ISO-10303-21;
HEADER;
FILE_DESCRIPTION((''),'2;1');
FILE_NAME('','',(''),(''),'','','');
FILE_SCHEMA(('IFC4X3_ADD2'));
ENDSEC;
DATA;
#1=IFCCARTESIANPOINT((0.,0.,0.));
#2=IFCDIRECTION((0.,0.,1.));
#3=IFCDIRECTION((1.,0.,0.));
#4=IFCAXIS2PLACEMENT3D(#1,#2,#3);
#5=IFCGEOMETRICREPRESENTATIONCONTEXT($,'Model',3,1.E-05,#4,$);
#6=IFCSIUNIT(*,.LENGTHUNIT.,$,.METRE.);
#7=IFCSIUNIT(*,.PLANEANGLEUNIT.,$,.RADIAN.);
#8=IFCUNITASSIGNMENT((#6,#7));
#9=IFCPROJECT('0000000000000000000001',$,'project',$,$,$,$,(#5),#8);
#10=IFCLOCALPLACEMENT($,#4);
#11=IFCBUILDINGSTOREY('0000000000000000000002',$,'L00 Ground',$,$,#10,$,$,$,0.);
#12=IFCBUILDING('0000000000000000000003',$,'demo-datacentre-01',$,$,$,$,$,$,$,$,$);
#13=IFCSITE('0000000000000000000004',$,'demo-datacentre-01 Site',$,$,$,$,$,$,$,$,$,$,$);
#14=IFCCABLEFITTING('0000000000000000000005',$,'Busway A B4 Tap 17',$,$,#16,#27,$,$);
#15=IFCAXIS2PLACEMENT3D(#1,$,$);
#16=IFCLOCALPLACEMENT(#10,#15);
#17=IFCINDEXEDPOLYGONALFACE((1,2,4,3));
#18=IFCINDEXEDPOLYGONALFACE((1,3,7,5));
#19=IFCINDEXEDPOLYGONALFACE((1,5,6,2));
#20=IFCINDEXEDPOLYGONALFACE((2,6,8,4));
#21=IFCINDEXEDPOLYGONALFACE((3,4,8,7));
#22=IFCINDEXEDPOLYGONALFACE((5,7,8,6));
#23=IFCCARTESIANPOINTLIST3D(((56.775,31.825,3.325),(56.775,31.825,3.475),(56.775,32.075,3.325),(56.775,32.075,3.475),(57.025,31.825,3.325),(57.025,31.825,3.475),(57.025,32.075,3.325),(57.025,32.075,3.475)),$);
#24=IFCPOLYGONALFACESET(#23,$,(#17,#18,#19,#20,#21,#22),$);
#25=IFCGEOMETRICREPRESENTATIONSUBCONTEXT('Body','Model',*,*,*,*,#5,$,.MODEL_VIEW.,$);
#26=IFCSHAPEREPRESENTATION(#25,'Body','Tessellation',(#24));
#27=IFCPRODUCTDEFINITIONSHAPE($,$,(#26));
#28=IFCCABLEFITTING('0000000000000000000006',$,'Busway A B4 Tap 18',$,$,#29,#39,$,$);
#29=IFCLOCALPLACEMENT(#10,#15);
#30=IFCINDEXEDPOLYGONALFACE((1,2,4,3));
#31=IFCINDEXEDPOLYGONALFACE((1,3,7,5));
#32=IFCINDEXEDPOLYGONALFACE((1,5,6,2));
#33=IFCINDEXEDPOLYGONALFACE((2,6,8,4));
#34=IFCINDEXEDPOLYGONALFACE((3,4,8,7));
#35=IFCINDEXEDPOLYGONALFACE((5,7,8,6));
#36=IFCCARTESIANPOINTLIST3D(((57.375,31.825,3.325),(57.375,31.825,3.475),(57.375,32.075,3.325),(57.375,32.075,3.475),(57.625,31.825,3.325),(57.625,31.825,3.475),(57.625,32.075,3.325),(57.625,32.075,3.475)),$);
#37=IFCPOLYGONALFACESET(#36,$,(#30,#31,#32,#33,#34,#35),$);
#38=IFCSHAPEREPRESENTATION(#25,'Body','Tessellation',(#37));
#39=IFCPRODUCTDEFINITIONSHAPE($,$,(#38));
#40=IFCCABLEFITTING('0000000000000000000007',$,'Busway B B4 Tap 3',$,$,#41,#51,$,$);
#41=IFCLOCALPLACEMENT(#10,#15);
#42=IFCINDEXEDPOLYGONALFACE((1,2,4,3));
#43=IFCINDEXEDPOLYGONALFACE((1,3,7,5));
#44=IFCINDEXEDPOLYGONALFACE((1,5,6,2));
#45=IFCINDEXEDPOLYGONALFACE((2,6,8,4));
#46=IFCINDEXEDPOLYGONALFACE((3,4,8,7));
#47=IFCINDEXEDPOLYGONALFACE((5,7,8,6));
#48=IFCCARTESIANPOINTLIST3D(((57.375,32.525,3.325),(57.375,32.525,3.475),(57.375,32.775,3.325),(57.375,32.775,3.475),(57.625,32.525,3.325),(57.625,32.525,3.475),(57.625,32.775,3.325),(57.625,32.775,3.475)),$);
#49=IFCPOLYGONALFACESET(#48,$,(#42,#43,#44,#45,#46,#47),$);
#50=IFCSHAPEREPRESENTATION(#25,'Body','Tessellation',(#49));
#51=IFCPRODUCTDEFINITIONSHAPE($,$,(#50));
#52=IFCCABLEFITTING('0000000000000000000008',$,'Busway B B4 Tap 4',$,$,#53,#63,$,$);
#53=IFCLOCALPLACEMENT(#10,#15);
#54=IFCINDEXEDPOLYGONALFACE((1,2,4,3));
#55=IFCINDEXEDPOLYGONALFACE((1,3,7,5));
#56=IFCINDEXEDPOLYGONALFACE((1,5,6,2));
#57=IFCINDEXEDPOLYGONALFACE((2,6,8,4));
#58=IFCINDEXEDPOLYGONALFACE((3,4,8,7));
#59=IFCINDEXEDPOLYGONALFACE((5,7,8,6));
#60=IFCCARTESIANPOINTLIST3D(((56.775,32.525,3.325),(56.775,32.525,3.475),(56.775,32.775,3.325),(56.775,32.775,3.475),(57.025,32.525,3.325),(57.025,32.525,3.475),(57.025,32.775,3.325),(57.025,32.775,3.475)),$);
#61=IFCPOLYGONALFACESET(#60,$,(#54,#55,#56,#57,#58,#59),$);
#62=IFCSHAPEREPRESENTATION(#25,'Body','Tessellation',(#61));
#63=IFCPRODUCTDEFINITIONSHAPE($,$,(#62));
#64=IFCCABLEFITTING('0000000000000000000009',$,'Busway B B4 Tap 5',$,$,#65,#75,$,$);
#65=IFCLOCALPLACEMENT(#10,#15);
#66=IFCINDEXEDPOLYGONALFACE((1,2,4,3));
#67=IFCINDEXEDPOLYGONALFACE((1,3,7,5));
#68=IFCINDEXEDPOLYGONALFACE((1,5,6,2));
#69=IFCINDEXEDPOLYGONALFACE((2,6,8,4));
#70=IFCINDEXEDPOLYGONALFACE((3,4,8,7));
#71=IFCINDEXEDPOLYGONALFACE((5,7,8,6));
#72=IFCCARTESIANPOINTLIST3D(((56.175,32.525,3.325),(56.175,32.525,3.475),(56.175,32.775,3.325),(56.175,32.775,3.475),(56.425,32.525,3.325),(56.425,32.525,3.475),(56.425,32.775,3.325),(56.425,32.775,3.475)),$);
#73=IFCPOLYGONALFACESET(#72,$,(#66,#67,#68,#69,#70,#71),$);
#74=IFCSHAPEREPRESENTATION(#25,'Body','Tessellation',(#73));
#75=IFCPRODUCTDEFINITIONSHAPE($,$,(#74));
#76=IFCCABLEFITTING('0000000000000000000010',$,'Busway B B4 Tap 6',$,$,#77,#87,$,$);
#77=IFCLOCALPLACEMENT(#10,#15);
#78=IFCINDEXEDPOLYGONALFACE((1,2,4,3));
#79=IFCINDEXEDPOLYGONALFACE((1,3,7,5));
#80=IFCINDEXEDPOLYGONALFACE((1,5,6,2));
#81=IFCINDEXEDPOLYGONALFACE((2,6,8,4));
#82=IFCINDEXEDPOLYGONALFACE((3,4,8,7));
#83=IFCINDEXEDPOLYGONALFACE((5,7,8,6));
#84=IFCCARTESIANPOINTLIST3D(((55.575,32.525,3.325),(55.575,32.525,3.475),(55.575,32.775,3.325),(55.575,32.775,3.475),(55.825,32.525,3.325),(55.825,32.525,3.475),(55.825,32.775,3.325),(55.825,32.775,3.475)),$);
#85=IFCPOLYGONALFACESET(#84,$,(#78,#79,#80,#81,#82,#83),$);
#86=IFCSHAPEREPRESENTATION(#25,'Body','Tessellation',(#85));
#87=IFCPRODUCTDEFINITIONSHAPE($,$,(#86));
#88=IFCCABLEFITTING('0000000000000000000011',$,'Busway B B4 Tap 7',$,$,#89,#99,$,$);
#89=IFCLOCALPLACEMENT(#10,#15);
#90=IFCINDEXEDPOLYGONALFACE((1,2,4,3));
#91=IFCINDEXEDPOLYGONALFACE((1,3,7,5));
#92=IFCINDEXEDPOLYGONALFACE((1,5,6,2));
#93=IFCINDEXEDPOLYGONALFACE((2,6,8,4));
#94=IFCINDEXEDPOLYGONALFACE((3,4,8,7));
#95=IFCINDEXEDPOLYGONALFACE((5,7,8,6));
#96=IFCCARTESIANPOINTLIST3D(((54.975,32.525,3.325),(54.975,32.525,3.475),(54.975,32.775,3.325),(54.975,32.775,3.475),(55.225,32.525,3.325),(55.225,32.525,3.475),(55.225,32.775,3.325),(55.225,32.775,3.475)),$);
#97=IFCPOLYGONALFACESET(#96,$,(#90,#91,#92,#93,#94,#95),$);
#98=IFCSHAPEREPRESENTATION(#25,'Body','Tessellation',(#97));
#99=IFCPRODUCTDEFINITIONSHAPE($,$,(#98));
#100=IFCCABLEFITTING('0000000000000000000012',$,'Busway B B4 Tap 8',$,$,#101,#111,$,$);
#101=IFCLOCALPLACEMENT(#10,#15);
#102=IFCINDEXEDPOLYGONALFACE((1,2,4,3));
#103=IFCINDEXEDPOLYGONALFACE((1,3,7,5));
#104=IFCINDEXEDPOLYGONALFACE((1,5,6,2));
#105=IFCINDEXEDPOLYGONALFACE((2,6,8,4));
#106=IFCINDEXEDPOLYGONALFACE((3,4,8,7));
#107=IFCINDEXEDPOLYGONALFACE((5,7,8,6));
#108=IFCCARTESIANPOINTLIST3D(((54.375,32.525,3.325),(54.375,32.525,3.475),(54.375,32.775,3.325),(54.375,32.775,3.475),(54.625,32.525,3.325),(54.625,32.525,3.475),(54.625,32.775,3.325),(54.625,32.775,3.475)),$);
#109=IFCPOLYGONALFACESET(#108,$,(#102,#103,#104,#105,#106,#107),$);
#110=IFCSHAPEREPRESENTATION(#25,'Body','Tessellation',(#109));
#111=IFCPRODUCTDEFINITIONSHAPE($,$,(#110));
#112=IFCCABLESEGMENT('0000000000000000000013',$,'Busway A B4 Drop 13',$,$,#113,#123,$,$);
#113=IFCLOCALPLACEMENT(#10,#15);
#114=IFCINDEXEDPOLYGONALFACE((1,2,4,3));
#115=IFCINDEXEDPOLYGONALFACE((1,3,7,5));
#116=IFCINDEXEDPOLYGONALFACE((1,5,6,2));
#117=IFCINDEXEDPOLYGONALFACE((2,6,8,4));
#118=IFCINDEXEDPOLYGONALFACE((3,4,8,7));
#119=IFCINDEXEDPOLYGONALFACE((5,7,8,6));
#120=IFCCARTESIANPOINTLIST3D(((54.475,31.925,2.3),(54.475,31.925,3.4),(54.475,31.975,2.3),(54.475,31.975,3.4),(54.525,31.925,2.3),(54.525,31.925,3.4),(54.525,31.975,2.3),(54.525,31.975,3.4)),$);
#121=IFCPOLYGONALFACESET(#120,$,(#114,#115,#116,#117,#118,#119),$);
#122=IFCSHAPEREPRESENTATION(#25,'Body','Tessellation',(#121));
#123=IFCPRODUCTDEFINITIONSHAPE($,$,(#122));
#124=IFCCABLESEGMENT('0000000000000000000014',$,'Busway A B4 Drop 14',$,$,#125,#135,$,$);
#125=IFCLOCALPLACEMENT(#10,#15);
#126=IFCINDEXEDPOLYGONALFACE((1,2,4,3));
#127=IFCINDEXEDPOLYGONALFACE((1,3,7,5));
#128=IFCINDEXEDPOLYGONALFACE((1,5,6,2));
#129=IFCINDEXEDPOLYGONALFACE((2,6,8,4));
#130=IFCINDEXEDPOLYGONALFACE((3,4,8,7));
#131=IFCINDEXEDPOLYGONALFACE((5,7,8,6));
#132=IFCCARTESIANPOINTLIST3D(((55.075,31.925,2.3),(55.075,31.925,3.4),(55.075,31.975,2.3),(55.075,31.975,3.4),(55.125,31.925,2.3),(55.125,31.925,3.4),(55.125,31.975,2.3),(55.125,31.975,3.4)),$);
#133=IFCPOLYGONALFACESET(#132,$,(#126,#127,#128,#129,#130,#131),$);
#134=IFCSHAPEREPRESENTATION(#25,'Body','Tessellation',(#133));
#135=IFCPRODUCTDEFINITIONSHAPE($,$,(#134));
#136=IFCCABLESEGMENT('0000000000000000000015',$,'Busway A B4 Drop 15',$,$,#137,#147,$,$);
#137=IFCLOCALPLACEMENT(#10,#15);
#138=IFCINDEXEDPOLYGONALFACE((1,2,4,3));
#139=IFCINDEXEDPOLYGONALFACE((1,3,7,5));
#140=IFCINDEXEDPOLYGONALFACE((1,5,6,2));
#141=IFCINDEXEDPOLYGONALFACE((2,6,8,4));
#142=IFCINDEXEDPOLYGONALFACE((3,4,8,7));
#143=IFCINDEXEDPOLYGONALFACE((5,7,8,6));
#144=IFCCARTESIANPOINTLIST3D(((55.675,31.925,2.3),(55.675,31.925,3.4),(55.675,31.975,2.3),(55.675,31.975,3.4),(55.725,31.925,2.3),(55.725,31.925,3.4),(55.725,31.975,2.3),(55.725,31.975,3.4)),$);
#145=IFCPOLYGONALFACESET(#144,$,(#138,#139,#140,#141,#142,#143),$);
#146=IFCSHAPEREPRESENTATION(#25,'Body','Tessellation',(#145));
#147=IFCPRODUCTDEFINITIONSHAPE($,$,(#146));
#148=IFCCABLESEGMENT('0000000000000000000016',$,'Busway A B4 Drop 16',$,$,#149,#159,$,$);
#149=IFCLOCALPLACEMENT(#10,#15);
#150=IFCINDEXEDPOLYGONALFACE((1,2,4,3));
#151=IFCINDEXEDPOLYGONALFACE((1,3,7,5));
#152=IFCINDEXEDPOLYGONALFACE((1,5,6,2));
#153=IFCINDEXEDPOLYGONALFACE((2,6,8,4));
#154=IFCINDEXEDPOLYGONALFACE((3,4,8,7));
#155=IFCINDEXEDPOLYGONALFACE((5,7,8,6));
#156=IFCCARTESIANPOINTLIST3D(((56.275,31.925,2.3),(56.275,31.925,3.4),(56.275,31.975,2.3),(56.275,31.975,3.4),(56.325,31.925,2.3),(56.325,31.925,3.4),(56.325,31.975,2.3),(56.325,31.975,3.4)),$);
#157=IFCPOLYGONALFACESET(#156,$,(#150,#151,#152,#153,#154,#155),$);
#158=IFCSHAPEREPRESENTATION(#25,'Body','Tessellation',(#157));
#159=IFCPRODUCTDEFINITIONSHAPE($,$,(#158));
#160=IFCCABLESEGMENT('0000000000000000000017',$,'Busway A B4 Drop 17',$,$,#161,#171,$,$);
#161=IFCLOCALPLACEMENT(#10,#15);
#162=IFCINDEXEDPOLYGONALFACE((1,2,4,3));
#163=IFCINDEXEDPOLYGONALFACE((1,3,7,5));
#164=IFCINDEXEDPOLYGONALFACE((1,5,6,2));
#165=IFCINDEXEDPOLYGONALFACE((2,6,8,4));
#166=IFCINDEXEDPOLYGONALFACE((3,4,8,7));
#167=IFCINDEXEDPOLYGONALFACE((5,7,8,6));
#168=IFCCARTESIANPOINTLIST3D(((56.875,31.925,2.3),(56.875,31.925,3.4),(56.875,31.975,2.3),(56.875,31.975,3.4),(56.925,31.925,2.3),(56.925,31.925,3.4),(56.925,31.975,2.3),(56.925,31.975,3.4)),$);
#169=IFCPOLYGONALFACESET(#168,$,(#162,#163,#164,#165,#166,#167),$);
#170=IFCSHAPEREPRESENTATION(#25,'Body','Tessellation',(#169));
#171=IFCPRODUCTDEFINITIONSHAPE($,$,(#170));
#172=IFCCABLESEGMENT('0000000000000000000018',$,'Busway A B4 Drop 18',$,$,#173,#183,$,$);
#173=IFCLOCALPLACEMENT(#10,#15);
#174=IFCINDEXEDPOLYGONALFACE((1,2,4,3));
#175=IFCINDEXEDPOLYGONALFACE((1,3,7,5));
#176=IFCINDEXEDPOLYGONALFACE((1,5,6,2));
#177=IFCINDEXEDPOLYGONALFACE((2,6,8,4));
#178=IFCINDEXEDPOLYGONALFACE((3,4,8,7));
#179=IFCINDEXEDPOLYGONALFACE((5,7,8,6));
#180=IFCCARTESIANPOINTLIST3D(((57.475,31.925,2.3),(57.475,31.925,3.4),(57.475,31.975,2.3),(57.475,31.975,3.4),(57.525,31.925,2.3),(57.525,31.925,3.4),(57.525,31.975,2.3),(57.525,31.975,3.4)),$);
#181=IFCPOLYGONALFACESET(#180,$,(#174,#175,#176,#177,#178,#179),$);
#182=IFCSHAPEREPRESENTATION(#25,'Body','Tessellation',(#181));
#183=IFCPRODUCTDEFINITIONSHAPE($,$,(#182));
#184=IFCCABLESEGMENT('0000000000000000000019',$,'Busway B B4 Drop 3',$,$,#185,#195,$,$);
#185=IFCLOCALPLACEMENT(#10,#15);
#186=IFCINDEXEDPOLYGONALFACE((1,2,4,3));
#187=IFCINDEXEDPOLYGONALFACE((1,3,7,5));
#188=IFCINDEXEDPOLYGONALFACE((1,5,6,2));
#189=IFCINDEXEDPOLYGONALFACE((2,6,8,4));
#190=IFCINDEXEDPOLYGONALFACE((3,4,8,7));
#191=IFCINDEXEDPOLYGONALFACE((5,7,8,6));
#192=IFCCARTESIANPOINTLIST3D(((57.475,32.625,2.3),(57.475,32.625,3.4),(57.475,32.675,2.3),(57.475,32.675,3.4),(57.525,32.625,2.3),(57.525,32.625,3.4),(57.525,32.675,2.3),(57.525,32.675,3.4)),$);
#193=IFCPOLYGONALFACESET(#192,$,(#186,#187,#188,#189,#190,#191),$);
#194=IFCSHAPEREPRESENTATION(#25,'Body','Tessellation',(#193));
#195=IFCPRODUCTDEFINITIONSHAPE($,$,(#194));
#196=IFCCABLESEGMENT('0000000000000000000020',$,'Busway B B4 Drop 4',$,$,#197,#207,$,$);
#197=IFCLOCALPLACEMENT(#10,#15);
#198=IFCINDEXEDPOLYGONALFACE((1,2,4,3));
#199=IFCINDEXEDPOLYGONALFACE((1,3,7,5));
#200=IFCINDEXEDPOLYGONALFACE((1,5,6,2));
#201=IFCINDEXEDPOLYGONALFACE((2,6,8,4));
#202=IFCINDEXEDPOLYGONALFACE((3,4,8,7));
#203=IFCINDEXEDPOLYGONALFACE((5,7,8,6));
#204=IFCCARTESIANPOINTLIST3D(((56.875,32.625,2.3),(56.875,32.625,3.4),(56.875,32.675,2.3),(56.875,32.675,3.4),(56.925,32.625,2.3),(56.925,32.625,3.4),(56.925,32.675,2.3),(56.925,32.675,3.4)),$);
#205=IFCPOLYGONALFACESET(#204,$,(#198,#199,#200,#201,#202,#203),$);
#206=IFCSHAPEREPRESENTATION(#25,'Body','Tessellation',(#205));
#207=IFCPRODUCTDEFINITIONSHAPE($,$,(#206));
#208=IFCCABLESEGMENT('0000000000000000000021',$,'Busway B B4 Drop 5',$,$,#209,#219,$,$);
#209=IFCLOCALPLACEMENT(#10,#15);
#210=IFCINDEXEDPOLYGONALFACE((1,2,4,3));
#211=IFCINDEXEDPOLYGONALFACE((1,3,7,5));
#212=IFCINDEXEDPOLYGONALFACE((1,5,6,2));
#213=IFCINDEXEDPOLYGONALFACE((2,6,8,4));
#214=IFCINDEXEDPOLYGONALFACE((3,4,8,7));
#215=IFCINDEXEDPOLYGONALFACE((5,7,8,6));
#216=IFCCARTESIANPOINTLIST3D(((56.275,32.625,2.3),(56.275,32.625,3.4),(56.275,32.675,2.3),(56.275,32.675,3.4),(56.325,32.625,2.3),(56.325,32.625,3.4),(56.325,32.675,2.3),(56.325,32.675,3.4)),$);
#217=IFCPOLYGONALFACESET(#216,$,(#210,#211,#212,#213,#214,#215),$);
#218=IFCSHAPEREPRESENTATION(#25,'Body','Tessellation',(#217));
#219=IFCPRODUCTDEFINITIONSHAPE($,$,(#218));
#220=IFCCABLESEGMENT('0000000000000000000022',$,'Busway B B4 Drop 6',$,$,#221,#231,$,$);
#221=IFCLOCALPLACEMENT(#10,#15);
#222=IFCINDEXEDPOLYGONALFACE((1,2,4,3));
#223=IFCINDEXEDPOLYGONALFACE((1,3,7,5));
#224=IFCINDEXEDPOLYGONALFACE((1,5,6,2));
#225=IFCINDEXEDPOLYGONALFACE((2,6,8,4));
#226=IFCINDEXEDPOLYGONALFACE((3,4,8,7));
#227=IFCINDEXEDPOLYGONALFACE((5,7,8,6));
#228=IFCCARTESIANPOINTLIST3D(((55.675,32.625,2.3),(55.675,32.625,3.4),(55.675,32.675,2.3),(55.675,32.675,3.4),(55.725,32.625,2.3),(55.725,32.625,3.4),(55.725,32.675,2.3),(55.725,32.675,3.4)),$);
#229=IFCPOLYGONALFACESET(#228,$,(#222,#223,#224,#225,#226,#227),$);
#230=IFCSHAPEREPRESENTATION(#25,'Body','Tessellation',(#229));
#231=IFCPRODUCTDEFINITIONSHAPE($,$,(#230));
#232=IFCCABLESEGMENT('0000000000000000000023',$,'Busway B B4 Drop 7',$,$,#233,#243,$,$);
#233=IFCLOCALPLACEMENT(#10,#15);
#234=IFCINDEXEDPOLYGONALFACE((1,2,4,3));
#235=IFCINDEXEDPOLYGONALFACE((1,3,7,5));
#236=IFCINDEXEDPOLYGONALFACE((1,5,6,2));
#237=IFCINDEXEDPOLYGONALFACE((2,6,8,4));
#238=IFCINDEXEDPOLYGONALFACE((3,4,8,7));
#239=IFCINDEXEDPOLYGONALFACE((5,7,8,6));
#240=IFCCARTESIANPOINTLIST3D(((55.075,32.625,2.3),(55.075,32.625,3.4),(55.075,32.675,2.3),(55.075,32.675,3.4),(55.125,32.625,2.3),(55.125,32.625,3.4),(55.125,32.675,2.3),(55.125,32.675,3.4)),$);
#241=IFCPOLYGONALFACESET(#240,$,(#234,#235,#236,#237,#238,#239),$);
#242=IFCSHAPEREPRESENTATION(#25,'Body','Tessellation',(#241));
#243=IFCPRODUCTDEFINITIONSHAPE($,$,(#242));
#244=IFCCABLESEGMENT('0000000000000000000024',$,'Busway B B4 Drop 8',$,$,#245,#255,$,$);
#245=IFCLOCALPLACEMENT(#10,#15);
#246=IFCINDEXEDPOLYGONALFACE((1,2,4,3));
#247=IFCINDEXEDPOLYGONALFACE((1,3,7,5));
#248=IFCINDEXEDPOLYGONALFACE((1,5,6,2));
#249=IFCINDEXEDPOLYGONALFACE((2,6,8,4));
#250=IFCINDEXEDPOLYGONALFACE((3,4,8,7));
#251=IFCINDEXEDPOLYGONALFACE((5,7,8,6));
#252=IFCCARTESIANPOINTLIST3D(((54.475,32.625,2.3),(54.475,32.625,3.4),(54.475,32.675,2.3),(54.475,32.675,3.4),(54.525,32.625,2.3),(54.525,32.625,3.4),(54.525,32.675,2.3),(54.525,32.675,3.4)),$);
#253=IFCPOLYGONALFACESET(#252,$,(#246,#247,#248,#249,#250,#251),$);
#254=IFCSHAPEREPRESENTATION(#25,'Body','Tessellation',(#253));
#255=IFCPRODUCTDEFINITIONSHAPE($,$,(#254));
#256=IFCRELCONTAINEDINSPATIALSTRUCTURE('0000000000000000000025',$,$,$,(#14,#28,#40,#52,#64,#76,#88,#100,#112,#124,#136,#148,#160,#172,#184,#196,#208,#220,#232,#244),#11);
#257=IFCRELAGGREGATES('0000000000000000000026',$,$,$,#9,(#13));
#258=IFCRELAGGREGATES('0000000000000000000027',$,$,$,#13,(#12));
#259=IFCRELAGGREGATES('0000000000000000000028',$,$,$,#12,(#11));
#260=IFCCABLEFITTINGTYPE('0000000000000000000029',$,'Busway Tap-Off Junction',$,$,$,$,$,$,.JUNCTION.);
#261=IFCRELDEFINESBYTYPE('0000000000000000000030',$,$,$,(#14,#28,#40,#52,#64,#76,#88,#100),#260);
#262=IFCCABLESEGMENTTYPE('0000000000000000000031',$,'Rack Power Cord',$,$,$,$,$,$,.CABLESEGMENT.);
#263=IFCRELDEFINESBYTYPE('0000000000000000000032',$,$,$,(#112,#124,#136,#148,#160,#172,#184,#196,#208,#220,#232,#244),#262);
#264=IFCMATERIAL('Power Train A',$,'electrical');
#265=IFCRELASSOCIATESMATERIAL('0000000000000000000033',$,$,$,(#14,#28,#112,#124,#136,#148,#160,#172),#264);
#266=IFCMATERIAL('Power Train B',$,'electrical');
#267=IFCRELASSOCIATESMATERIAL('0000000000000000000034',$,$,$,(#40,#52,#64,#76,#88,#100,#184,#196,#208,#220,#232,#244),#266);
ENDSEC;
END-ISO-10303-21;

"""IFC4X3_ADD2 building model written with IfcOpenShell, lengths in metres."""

from ifc_helpers import new_model, si_unit, frame, origin_with_axes, place, context, subcontext, project, spatial, rectangle, extrude, material, type_object, element, save


model = new_model("IFC4X3_ADD2")

# Units and contexts
model_context = context("Model", 3, precision=1e-05, world=origin_with_axes())
body_context = subcontext(model_context, "Body", "Model", "MODEL_VIEW")
ifc_project = project(units=[si_unit("LENGTHUNIT", "METRE"), si_unit("PLANEANGLEUNIT", "RADIAN")], contexts=[model_context])

# Site, building, storey
site = spatial("IfcSite", under=ifc_project, Name="demo-datacentre-01 Site")
building = spatial("IfcBuilding", under=site, Name="demo-datacentre-01")
storey_placement = place(None, origin_with_axes())
storey = spatial("IfcBuildingStorey", under=building, at=storey_placement, Name="L00 Ground", Elevation=0.0)

# Shared definitions
ifc_material_1 = material(Name="Power Train A", Category="electrical")
ifc_material_2 = material(Name="Power Train B", Category="electrical")

# Cable fittings
cable_fitting_type = type_object("IfcCableFittingType", Name="Busway Tap-Off Junction", PredefinedType="JUNCTION")
for number, where, z_axis, x_axis, name in (
    (1, (56.9, 31.95, 3.325), (0.0, 0.0, 1.0), (1.0, 0.0, 0.0), "Busway A B4 Tap 17"),
    (2, (57.5, 31.95, 3.325), (0.0, 0.0, 1.0), (1.0, 0.0, 0.0), "Busway A B4 Tap 18"),
):
    element("IfcCableFitting", number, at=place(storey_placement, frame(where, z_axis=z_axis, x_axis=x_axis)), inside=storey, type_object=cable_fitting_type, material=ifc_material_1, Name=name, context=body_context, shape_type="SweptSolid", body=[
        extrude(rectangle(XDim=0.25, YDim=0.25), origin_with_axes(), (0.0, 0.0, 1.0), 0.15),
    ])
for number, where, z_axis, x_axis, name in (
    (3, (57.5, 32.65, 3.325), (0.0, 0.0, 1.0), (1.0, 0.0, 0.0), "Busway B B4 Tap 3"),
    (4, (56.9, 32.65, 3.325), (0.0, 0.0, 1.0), (1.0, 0.0, 0.0), "Busway B B4 Tap 4"),
    (5, (56.3, 32.65, 3.325), (0.0, 0.0, 1.0), (1.0, 0.0, 0.0), "Busway B B4 Tap 5"),
    (6, (55.7, 32.65, 3.325), (0.0, 0.0, 1.0), (1.0, 0.0, 0.0), "Busway B B4 Tap 6"),
    (7, (55.1, 32.65, 3.325), (0.0, 0.0, 1.0), (1.0, 0.0, 0.0), "Busway B B4 Tap 7"),
    (8, (54.5, 32.65, 3.325), (0.0, 0.0, 1.0), (1.0, 0.0, 0.0), "Busway B B4 Tap 8"),
):
    element("IfcCableFitting", number, at=place(storey_placement, frame(where, z_axis=z_axis, x_axis=x_axis)), inside=storey, type_object=cable_fitting_type, material=ifc_material_2, Name=name, context=body_context, shape_type="SweptSolid", body=[
        extrude(rectangle(XDim=0.25, YDim=0.25), origin_with_axes(), (0.0, 0.0, 1.0), 0.15),
    ])

# Cable segments
cable_segment_type_1 = type_object("IfcCableSegmentType", Name="Rack Power Cord", PredefinedType="CABLESEGMENT")
for number, where, z_axis, x_axis, name in (
    (9, (54.5, 31.95, 3.4), (0.0, 0.0, -1.0), (1.0, 0.0, 0.0), "Busway A B4 Drop 13"),
    (10, (55.1, 31.95, 3.4), (0.0, 0.0, -1.0), (1.0, 0.0, 0.0), "Busway A B4 Drop 14"),
    (11, (55.7, 31.95, 3.4), (0.0, 0.0, -1.0), (1.0, 0.0, 0.0), "Busway A B4 Drop 15"),
    (12, (56.3, 31.95, 3.4), (0.0, 0.0, -1.0), (1.0, 0.0, 0.0), "Busway A B4 Drop 16"),
    (13, (56.9, 31.95, 3.4), (0.0, 0.0, -1.0), (1.0, 0.0, 0.0), "Busway A B4 Drop 17"),
    (14, (57.5, 31.95, 3.4), (0.0, 0.0, -1.0), (1.0, 0.0, 0.0), "Busway A B4 Drop 18"),
):
    element("IfcCableSegment", number, at=place(storey_placement, frame(where, z_axis=z_axis, x_axis=x_axis)), inside=storey, type_object=cable_segment_type_1, material=ifc_material_1, Name=name, context=body_context, shape_type="SweptSolid", body=[
        extrude(rectangle(XDim=0.05, YDim=0.05), origin_with_axes(), (0.0, 0.0, 1.0), 1.1),
    ])
for number, where, z_axis, x_axis, name in (
    (15, (57.5, 32.65, 3.4), (0.0, 0.0, -1.0), (1.0, 0.0, 0.0), "Busway B B4 Drop 3"),
    (16, (56.9, 32.65, 3.4), (0.0, 0.0, -1.0), (1.0, 0.0, 0.0), "Busway B B4 Drop 4"),
    (17, (56.3, 32.65, 3.4), (0.0, 0.0, -1.0), (1.0, 0.0, 0.0), "Busway B B4 Drop 5"),
    (18, (55.7, 32.65, 3.4), (0.0, 0.0, -1.0), (1.0, 0.0, 0.0), "Busway B B4 Drop 6"),
    (19, (55.1, 32.65, 3.4), (0.0, 0.0, -1.0), (1.0, 0.0, 0.0), "Busway B B4 Drop 7"),
    (20, (54.5, 32.65, 3.4), (0.0, 0.0, -1.0), (1.0, 0.0, 0.0), "Busway B B4 Drop 8"),
):
    element("IfcCableSegment", number, at=place(storey_placement, frame(where, z_axis=z_axis, x_axis=x_axis)), inside=storey, type_object=cable_segment_type_1, material=ifc_material_2, Name=name, context=body_context, shape_type="SweptSolid", body=[
        extrude(rectangle(XDim=0.05, YDim=0.05), origin_with_axes(), (0.0, 0.0, 1.0), 1.1),
    ])

save(model, "model.ifc")
